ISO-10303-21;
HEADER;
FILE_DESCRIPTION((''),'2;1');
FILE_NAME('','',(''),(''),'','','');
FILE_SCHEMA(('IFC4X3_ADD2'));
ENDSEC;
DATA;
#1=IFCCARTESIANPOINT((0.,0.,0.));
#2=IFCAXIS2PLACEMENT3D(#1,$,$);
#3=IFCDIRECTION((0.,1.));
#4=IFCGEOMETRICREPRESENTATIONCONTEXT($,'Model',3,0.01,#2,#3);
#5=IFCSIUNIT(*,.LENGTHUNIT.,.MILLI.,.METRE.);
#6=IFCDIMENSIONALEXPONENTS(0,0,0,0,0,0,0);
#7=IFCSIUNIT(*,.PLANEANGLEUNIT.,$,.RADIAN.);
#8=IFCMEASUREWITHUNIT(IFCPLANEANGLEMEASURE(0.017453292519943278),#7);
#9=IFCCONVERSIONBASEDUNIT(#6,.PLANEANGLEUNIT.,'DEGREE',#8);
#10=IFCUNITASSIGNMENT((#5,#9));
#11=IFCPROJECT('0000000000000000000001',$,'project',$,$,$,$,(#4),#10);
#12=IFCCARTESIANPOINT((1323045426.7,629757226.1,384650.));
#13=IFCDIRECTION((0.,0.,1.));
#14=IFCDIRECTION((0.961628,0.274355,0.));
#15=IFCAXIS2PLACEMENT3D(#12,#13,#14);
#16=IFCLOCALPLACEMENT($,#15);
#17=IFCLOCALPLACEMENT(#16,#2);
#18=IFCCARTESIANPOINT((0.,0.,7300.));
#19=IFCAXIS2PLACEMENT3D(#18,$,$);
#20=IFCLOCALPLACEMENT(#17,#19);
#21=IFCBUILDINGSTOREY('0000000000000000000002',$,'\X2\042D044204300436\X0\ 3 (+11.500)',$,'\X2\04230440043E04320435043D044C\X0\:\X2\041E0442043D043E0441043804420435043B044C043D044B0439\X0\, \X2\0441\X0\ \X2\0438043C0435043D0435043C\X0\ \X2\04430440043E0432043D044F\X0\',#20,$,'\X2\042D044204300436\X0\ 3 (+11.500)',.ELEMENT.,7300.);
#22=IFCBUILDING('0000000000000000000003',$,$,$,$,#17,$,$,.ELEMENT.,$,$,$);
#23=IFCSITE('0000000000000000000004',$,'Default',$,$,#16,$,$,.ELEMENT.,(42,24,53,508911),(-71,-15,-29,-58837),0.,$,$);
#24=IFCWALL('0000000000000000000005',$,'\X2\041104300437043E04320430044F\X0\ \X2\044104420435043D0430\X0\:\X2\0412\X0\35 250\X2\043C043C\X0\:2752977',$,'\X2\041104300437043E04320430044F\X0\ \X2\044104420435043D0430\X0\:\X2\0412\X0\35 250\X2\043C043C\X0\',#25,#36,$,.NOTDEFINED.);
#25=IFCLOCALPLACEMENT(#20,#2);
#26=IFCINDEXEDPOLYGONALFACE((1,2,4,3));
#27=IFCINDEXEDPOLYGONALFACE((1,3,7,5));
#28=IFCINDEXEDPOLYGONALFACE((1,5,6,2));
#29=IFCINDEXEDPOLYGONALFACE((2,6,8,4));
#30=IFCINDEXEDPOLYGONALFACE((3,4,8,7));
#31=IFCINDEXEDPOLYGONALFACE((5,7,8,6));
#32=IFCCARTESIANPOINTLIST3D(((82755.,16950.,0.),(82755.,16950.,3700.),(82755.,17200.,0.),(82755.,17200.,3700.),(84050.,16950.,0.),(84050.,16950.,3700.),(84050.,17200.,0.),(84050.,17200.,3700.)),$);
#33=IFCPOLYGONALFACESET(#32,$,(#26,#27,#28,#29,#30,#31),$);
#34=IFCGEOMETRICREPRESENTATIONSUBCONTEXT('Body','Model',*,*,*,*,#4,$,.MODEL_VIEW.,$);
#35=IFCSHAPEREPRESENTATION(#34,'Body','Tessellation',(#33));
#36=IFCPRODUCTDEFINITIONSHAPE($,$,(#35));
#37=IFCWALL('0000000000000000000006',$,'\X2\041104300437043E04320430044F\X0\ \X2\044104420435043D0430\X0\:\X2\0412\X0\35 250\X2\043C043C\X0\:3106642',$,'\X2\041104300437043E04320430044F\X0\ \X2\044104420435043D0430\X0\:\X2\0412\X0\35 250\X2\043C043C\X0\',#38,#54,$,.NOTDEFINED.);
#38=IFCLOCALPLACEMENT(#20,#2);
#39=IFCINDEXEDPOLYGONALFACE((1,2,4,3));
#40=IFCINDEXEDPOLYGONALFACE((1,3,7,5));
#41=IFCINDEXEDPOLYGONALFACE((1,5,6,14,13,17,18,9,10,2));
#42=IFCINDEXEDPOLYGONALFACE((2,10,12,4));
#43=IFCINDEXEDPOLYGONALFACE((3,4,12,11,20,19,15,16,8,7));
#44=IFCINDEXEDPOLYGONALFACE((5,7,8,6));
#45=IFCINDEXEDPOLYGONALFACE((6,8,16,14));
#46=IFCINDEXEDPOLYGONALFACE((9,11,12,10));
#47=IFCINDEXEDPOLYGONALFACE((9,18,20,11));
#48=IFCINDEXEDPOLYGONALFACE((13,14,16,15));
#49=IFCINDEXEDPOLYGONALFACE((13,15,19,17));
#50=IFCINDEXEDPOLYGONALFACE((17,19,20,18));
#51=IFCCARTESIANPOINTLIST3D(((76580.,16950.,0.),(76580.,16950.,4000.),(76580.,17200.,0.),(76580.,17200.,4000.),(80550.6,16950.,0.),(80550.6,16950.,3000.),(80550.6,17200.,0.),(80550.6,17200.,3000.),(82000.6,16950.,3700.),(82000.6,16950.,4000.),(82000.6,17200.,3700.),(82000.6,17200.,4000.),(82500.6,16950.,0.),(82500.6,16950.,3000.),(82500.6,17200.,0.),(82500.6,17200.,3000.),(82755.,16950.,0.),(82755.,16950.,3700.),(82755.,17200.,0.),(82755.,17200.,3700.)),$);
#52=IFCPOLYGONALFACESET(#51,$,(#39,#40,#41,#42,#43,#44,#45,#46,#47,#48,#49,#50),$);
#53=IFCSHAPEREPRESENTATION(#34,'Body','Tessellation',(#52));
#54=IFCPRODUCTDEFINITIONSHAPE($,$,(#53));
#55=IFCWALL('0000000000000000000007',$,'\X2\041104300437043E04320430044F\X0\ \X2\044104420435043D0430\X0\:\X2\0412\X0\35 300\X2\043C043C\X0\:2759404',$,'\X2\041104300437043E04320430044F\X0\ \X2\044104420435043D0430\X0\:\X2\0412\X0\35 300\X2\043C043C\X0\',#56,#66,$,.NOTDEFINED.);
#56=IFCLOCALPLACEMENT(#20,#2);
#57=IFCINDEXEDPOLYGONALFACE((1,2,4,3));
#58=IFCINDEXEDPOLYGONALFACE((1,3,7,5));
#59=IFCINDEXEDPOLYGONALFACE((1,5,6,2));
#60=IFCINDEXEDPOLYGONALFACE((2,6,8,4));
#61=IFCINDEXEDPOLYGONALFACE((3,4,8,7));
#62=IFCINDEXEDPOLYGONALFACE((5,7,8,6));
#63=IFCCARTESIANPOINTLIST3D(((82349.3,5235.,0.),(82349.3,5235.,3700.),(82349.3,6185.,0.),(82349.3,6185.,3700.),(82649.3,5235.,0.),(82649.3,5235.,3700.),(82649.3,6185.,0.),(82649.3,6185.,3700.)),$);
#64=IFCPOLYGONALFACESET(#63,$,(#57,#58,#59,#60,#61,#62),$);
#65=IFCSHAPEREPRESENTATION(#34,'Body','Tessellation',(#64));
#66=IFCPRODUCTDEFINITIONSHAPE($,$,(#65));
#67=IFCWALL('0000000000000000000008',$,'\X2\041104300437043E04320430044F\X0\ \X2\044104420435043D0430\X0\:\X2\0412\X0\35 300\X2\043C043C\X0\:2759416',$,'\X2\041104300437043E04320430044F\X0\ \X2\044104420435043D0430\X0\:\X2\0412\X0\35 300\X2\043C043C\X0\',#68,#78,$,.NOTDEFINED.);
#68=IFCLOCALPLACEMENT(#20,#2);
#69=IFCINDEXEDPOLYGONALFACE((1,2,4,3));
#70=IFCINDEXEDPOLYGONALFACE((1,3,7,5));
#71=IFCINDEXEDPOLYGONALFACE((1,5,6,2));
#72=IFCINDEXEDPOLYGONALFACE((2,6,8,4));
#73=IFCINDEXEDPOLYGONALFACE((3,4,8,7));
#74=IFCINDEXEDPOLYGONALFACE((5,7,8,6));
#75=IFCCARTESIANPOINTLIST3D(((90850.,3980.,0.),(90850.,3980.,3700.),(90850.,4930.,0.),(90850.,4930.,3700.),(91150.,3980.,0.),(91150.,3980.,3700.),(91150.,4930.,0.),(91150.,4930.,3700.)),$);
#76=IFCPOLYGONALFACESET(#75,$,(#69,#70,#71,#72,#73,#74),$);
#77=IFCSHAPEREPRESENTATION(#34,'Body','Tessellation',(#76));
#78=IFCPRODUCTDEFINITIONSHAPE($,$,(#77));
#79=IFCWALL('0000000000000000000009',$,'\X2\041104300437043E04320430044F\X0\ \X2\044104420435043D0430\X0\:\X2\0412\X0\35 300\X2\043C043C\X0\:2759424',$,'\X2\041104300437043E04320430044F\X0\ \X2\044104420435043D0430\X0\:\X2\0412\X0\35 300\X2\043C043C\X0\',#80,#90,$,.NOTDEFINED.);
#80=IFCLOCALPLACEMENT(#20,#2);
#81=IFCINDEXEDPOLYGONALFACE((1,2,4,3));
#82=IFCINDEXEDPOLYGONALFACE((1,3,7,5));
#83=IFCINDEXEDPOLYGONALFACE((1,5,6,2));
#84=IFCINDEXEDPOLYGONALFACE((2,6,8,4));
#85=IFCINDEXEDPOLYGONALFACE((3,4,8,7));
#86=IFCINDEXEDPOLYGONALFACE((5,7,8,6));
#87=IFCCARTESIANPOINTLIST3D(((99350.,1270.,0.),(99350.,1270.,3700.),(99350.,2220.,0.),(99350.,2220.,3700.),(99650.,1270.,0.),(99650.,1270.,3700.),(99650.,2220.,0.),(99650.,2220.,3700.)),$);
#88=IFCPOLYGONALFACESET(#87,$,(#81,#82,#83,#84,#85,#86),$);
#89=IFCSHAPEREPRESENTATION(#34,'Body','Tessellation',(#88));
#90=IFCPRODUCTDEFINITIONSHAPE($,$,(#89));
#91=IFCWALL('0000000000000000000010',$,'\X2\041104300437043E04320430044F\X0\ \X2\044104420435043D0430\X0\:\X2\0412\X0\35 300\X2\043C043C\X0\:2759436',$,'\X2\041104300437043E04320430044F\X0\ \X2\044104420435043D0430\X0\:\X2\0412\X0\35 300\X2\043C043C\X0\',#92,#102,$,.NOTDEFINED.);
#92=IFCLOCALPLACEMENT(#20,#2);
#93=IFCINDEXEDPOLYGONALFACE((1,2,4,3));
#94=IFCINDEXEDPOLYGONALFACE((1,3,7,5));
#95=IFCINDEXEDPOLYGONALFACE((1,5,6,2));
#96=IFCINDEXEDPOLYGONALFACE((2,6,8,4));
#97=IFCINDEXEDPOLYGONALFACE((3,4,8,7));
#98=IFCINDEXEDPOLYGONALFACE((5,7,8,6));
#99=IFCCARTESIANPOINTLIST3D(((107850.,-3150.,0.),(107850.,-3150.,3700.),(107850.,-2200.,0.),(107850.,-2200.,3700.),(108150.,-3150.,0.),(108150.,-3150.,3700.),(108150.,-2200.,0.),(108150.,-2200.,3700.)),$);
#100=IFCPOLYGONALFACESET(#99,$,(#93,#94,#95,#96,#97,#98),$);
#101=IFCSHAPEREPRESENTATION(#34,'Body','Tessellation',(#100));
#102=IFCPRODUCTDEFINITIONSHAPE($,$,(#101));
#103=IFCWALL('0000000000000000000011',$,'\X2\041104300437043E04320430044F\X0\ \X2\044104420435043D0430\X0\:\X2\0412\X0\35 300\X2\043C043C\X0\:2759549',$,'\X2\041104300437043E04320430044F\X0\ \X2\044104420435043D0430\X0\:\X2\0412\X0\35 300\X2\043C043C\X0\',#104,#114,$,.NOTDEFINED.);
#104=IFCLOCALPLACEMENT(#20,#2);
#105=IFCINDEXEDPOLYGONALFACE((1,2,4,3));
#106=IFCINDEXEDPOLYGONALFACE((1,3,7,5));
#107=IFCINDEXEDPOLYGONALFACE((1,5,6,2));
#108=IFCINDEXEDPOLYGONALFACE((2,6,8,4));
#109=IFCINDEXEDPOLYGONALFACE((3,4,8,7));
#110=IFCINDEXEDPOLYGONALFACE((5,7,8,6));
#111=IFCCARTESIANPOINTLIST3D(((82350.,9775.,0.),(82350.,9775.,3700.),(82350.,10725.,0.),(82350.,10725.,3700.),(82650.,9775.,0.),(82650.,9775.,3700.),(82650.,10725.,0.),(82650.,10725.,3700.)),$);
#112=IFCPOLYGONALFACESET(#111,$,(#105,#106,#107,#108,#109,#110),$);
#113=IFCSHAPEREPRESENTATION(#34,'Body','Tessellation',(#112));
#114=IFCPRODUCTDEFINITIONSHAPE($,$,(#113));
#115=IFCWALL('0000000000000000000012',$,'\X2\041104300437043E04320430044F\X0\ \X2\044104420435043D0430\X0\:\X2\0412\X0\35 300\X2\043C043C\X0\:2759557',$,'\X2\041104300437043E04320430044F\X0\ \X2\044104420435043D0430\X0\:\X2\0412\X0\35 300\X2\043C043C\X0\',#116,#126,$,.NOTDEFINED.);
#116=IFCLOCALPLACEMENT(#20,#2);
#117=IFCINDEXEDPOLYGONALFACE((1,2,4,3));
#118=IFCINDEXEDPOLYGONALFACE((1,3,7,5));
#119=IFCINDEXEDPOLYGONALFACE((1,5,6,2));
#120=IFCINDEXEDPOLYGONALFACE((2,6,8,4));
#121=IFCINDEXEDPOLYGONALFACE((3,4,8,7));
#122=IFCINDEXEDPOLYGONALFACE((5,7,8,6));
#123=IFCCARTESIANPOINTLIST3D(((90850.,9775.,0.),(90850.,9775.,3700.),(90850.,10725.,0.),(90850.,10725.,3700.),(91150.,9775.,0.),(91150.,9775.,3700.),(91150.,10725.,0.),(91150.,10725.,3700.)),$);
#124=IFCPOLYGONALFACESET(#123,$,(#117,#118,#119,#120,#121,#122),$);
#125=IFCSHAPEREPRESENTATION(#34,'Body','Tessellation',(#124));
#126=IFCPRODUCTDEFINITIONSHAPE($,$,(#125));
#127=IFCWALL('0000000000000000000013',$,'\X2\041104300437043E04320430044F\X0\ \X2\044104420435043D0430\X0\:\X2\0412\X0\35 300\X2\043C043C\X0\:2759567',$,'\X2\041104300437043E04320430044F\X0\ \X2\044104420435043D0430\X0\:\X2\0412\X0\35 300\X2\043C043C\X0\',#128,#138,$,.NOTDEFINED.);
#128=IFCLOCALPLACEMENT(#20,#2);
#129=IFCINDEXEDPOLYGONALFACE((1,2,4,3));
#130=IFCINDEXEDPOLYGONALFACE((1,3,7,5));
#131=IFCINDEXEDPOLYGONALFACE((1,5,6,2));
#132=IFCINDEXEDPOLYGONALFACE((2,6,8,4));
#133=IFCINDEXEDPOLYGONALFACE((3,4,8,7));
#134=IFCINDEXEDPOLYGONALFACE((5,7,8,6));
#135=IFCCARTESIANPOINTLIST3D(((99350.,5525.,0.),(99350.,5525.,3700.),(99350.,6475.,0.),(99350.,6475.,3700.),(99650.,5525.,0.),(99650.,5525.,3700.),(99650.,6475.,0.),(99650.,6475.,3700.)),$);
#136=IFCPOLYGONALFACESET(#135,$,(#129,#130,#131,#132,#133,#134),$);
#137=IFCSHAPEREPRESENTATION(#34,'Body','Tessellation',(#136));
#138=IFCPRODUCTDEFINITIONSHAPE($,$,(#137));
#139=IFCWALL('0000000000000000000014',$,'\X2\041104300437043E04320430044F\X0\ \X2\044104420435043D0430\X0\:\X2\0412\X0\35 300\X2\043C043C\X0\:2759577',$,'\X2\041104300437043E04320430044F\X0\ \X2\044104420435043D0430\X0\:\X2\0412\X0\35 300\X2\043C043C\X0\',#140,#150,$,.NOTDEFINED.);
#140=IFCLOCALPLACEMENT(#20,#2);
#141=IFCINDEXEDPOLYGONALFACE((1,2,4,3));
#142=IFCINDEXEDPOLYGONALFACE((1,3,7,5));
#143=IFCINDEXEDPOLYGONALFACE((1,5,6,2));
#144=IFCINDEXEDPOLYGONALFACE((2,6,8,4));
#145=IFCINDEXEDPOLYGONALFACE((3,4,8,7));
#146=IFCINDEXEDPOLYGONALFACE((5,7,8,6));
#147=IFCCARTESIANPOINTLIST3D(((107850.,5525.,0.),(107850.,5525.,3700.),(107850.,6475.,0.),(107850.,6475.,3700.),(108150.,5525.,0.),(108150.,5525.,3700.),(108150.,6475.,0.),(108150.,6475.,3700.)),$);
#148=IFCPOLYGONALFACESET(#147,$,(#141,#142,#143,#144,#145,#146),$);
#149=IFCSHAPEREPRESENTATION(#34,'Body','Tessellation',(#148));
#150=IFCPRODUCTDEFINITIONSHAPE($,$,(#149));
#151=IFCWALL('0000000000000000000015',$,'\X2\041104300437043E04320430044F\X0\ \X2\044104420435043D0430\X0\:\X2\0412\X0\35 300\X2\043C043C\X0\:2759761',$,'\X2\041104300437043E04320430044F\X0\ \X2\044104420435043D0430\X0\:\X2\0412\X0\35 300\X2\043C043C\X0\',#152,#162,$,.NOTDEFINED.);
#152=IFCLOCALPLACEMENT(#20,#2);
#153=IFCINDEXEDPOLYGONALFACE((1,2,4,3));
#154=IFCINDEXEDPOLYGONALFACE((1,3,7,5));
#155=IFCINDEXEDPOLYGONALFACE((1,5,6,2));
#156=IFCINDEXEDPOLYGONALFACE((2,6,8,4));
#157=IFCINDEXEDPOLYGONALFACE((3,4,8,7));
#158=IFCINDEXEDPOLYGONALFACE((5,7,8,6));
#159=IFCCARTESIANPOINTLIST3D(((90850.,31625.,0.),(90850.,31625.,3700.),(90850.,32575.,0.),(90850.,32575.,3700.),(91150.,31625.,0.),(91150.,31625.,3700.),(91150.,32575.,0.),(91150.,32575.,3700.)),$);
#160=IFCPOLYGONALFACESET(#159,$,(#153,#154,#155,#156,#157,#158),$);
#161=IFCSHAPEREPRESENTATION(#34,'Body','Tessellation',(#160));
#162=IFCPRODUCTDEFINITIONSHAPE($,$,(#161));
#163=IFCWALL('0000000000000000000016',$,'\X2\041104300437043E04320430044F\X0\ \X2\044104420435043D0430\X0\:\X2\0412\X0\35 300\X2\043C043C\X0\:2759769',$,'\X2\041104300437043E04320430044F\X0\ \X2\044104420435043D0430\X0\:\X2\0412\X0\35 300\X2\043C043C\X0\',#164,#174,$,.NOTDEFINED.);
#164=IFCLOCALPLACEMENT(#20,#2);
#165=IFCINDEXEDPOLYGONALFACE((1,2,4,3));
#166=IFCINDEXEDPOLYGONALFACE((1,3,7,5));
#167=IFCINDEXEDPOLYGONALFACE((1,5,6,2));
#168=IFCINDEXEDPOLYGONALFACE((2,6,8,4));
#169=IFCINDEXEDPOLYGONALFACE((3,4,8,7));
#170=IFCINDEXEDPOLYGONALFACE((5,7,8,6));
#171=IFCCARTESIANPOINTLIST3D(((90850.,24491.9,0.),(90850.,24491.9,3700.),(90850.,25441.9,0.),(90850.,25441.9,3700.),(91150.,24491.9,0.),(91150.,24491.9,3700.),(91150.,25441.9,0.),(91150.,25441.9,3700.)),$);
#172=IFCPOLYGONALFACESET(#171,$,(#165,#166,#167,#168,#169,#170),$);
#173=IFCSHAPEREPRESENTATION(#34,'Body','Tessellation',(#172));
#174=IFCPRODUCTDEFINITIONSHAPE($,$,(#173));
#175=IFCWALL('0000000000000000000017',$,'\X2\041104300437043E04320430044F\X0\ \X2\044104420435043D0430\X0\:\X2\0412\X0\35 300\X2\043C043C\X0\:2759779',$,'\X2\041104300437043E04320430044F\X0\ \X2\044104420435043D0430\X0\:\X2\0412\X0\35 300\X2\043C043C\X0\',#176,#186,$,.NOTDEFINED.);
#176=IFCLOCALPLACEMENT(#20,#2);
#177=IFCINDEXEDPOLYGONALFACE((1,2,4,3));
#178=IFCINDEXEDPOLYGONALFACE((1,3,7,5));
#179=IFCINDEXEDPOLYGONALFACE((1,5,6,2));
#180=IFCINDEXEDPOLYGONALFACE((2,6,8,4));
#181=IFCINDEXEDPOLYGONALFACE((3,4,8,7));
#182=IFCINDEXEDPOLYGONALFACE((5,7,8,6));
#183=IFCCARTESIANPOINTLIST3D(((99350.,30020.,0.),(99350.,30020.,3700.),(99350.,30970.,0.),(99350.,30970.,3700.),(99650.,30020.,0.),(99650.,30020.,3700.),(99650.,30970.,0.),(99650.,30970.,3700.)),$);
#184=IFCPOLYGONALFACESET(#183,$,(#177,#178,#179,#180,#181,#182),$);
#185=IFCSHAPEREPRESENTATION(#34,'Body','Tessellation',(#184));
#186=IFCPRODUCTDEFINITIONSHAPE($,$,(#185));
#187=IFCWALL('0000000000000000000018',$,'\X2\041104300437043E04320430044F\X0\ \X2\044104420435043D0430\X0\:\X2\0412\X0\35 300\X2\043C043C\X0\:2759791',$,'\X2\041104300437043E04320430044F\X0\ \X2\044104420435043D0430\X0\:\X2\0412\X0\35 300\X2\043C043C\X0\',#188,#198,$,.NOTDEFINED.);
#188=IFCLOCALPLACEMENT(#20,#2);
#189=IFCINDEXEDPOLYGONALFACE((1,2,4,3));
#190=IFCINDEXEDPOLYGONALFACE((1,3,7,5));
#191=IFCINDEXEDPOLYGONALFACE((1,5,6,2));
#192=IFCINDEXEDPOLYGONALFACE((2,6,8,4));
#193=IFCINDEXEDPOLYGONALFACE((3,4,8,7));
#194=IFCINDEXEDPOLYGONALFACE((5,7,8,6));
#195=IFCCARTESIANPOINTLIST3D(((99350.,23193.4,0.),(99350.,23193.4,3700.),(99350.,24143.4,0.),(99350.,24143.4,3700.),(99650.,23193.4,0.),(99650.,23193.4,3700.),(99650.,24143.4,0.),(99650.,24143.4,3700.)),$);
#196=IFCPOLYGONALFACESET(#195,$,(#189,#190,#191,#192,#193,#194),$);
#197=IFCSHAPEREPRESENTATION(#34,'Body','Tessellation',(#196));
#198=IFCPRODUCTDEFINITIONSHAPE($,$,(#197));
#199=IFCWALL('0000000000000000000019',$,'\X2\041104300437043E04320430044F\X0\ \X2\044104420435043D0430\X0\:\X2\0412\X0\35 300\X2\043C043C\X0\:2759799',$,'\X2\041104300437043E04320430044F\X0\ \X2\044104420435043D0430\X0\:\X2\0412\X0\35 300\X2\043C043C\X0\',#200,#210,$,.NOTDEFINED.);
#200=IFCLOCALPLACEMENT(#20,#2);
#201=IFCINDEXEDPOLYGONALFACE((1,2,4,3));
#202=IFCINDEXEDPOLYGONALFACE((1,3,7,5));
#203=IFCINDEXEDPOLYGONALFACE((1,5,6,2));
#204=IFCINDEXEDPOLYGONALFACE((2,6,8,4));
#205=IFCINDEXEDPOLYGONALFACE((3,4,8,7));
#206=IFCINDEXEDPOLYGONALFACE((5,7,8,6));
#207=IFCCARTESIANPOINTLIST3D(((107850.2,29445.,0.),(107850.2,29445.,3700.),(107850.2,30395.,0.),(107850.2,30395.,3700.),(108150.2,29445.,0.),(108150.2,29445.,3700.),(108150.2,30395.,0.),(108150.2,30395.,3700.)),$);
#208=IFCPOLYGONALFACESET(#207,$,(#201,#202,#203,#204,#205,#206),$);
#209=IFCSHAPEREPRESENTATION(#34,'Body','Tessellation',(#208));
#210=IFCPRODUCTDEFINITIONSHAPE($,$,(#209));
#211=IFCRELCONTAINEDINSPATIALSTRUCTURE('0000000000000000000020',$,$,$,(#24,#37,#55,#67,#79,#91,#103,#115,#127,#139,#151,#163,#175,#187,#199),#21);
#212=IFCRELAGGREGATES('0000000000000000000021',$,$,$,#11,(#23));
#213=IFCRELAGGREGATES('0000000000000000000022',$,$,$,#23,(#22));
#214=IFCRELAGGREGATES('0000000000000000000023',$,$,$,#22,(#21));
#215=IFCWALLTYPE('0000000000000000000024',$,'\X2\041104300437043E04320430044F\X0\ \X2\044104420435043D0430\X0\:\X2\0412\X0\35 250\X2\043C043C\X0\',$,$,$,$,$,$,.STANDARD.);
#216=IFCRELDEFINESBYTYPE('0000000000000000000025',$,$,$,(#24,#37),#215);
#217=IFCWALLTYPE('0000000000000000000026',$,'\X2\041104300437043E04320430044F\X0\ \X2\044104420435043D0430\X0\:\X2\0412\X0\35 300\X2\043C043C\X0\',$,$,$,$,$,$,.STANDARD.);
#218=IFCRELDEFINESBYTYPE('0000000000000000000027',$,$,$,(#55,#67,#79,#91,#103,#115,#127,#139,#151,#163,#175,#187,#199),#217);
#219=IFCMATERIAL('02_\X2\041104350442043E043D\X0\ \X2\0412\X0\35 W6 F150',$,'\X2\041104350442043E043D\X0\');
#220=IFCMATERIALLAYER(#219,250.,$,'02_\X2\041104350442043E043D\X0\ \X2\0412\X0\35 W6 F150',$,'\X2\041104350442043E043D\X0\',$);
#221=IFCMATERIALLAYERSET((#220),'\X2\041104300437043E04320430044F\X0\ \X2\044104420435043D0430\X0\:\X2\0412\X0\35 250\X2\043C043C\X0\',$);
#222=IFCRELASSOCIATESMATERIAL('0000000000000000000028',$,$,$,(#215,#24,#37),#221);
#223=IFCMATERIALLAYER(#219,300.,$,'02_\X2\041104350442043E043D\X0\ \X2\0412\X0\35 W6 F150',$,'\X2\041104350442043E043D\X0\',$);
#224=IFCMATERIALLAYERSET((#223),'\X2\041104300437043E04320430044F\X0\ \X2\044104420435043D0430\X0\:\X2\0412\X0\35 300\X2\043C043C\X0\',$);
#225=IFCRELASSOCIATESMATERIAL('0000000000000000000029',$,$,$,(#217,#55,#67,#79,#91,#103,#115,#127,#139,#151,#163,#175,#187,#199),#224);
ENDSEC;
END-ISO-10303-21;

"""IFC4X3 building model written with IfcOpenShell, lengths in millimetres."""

from ifc_helpers import new_model, entity, si_unit, converted_unit, direction, frame, frame_2d, origin, origin_2d_with_axis, place, context, subcontext, project, spatial, rectangle, extrude, clip, halfspace, material, layer, layer_set, type_object, element, save


model = new_model("IFC4X3")

# Units and contexts
model_context = context("Model", 3, precision=0.01, world=origin(), true_north=direction((0.0, 1.0)))
body_context = subcontext(model_context, "Body", "Model", "MODEL_VIEW")
ifc_project = project(units=[si_unit("LENGTHUNIT", "METRE", prefix="MILLI"), converted_unit("PLANEANGLEUNIT", "DEGREE", entity("IfcPlaneAngleMeasure", 0.017453292519943278), si_unit("PLANEANGLEUNIT", "RADIAN"), dimensions=[0, 0, 0, 0, 0, 0, 0])], contexts=[model_context])

# Site, building, storey
site_placement = place(None, frame((1323045426.7, 629757226.1, 384650.0), z_axis=(0.0, 0.0, 1.0), x_axis=(0.961628, 0.274355, 0.0)))
site = spatial("IfcSite", under=ifc_project, at=site_placement, Name="Default", CompositionType="ELEMENT", RefLatitude=(42, 24, 53, 508911), RefLongitude=(-71, -15, -29, -58837), RefElevation=0.0)
building_placement = place(site_placement, origin())
building = spatial("IfcBuilding", under=site, at=building_placement, CompositionType="ELEMENT")
storey_placement = place(building_placement, frame((0.0, 0.0, 7300.0)))
storey = spatial("IfcBuildingStorey", under=building, at=storey_placement, Name="Этаж 3 (+11.500)", ObjectType="Уровень:Относительный, с именем уровня", LongName="Этаж 3 (+11.500)", CompositionType="ELEMENT", Elevation=7300.0)

# Wall
ifc_material = material(Name="02_Бетон В35 W6 F150", Category="Бетон")
ifc_layer_1 = layer(ifc_material, 250.0, Name="02_Бетон В35 W6 F150", Category="Бетон")
ifc_layer_set_1 = layer_set([ifc_layer_1], Name="Базовая стена:В35 250мм")
wall_type_1 = type_object("IfcWallType", Name="Базовая стена:В35 250мм", PredefinedType="STANDARD", material=ifc_layer_set_1)
wall_1_placement = place(storey_placement, frame((84050.0, 17075.0, 0.0), z_axis=(0.0, 0.0, 1.0), x_axis=(-1.0, 0.0, 0.0)))
element("IfcWall", 1, at=wall_1_placement, inside=storey, type_object=wall_type_1, material=ifc_layer_set_1, Name="Базовая стена:В35 250мм:2752977", ObjectType="Базовая стена:В35 250мм", PredefinedType="NOTDEFINED", context=body_context, shape_type="SweptSolid", body=[
    extrude(rectangle(XDim=1295.0, YDim=250.0, at=frame_2d((647.5, 0.0), x_axis=(-1.0, 0.0))), origin(), (0.0, 0.0, 1.0), 3700.0),
])

# Wall, openings
wall_2_placement = place(storey_placement, frame((82755.0, 17075.0, 0.0), z_axis=(0.0, 0.0, 1.0), x_axis=(-1.0, 0.0, 0.0)))
wall_2 = element("IfcWall", 2, at=wall_2_placement, inside=storey, type_object=wall_type_1, material=ifc_layer_set_1, Name="Базовая стена:В35 250мм:3106642", ObjectType="Базовая стена:В35 250мм", PredefinedType="NOTDEFINED", context=body_context, shape_type="Clipping", body=[
    clip(extrude(rectangle(XDim=6175.0, YDim=250.0, at=frame_2d((3087.5, 0.0), x_axis=(-1.0, 0.0))), origin(), (0.0, 0.0, 1.0), 4000.0), halfspace(frame((754.4, -125.0, 4000.0), z_axis=(0.0, 0.0, 1.0), x_axis=(0.0, 1.0, 0.0)), False)),
])
opening_1_placement = place(wall_2_placement, origin())
element("IfcOpeningElement", 3, at=opening_1_placement, cuts=wall_2, PredefinedType="OPENING", context=body_context, shape_type="SweptSolid", body=[
    extrude(rectangle(XDim=300.0, YDim=754.4, at=frame_2d((0.0, 0.0), x_axis=(0.0, 1.0))), frame((377.2, 125.0, 3850.0), z_axis=(0.0, -1.0, 0.0), x_axis=(-1.0, 0.0, 0.0)), (0.0, 0.0, 1.0), 250.0),
])
opening_2_placement = place(wall_2_placement, frame((82755.0, 17075.0, 0.0), z_axis=(0.0, 0.0, 1.0), x_axis=(-1.0, 0.0, 0.0)))
element("IfcOpeningElement", 4, at=opening_2_placement, cuts=wall_2, PredefinedType="OPENING", context=body_context, shape_type="SweptSolid", body=[
    extrude(rectangle(XDim=3000.0, YDim=1950.0, at=origin_2d_with_axis()), frame((81525.6, 18724.0, 1500.0), z_axis=(0.0, -1.0, 0.0), x_axis=(0.0, 0.0, -1.0)), (0.0, 0.0, 1.0), 3048.0),
])

# Walls
ifc_layer_2 = layer(ifc_material, 300.0, Name="02_Бетон В35 W6 F150", Category="Бетон")
ifc_layer_set_2 = layer_set([ifc_layer_2], Name="Базовая стена:В35 300мм")
wall_type_2 = type_object("IfcWallType", Name="Базовая стена:В35 300мм", PredefinedType="STANDARD", material=ifc_layer_set_2)
wall_3_placement = place(storey_placement, frame((82499.3, 5235.0, 0.0), z_axis=(0.0, 0.0, 1.0), x_axis=(0.0, 1.0, 0.0)))
element("IfcWall", 5, at=wall_3_placement, inside=storey, type_object=wall_type_2, material=ifc_layer_set_2, Name="Базовая стена:В35 300мм:2759404", ObjectType="Базовая стена:В35 300мм", PredefinedType="NOTDEFINED", context=body_context, shape_type="SweptSolid", body=[
    extrude(rectangle(XDim=950.0, YDim=300.0, at=frame_2d((475.0, 0.0), x_axis=(-1.0, 0.0))), origin(), (0.0, 0.0, 1.0), 3700.0),
])
wall_4_placement = place(storey_placement, frame((91000.0, 3980.0, 0.0), z_axis=(0.0, 0.0, 1.0), x_axis=(0.0, 1.0, 0.0)))
element("IfcWall", 6, at=wall_4_placement, inside=storey, type_object=wall_type_2, material=ifc_layer_set_2, Name="Базовая стена:В35 300мм:2759416", ObjectType="Базовая стена:В35 300мм", PredefinedType="NOTDEFINED", context=body_context, shape_type="SweptSolid", body=[
    extrude(rectangle(XDim=950.0, YDim=300.0, at=frame_2d((475.0, 0.0), x_axis=(-1.0, 0.0))), origin(), (0.0, 0.0, 1.0), 3700.0),
])
for number, where, z_axis, x_axis, name in (
    (7, (99500.0, 1270.0, 0.0), (0.0, 0.0, 1.0), (0.0, 1.0, 0.0), "Базовая стена:В35 300мм:2759424"),
    (8, (108000.0, -3150.0, 0.0), (0.0, 0.0, 1.0), (0.0, 1.0, 0.0), "Базовая стена:В35 300мм:2759436"),
):
    element("IfcWall", number, at=place(storey_placement, frame(where, z_axis=z_axis, x_axis=x_axis)), inside=storey, type_object=wall_type_2, material=ifc_layer_set_2, Name=name, ObjectType="Базовая стена:В35 300мм", PredefinedType="NOTDEFINED", context=body_context, shape_type="SweptSolid", body=[
        extrude(rectangle(XDim=950.0, YDim=300.0, at=frame_2d((475.0, 0.0), x_axis=(-1.0, 0.0))), origin(), (0.0, 0.0, 1.0), 3700.0),
    ])
wall_5_placement = place(storey_placement, frame((82500.0, 9775.0, 0.0), z_axis=(0.0, 0.0, 1.0), x_axis=(0.0, 1.0, 0.0)))
element("IfcWall", 9, at=wall_5_placement, inside=storey, type_object=wall_type_2, material=ifc_layer_set_2, Name="Базовая стена:В35 300мм:2759549", ObjectType="Базовая стена:В35 300мм", PredefinedType="NOTDEFINED", context=body_context, shape_type="SweptSolid", body=[
    extrude(rectangle(XDim=950.0, YDim=300.0, at=frame_2d((475.0, 0.0), x_axis=(-1.0, 0.0))), origin(), (0.0, 0.0, 1.0), 3700.0),
])
for number, where, z_axis, x_axis, name in (
    (10, (91000.0, 9775.0, 0.0), (0.0, 0.0, 1.0), (0.0, 1.0, 0.0), "Базовая стена:В35 300мм:2759557"),
    (11, (99500.0, 5525.0, 0.0), (0.0, 0.0, 1.0), (0.0, 1.0, 0.0), "Базовая стена:В35 300мм:2759567"),
    (12, (108000.0, 5525.0, 0.0), (0.0, 0.0, 1.0), (0.0, 1.0, 0.0), "Базовая стена:В35 300мм:2759577"),
    (13, (91000.0, 31625.0, 0.0), (0.0, 0.0, 1.0), (0.0, 1.0, 0.0), "Базовая стена:В35 300мм:2759761"),
    (14, (91000.0, 24491.9, 0.0), (0.0, 0.0, 1.0), (0.0, 1.0, 0.0), "Базовая стена:В35 300мм:2759769"),
    (15, (99500.0, 30020.0, 0.0), (0.0, 0.0, 1.0), (0.0, 1.0, 0.0), "Базовая стена:В35 300мм:2759779"),
    (16, (99500.0, 23193.4, 0.0), (0.0, 0.0, 1.0), (0.0, 1.0, 0.0), "Базовая стена:В35 300мм:2759791"),
    (17, (108000.2, 29445.0, 0.0), (0.0, 0.0, 1.0), (0.0, 1.0, 0.0), "Базовая стена:В35 300мм:2759799"),
):
    element("IfcWall", number, at=place(storey_placement, frame(where, z_axis=z_axis, x_axis=x_axis)), inside=storey, type_object=wall_type_2, material=ifc_layer_set_2, Name=name, ObjectType="Базовая стена:В35 300мм", PredefinedType="NOTDEFINED", context=body_context, shape_type="SweptSolid", body=[
        extrude(rectangle(XDim=950.0, YDim=300.0, at=frame_2d((475.0, 0.0), x_axis=(-1.0, 0.0))), origin(), (0.0, 0.0, 1.0), 3700.0),
    ])

save(model, "model.ifc")
